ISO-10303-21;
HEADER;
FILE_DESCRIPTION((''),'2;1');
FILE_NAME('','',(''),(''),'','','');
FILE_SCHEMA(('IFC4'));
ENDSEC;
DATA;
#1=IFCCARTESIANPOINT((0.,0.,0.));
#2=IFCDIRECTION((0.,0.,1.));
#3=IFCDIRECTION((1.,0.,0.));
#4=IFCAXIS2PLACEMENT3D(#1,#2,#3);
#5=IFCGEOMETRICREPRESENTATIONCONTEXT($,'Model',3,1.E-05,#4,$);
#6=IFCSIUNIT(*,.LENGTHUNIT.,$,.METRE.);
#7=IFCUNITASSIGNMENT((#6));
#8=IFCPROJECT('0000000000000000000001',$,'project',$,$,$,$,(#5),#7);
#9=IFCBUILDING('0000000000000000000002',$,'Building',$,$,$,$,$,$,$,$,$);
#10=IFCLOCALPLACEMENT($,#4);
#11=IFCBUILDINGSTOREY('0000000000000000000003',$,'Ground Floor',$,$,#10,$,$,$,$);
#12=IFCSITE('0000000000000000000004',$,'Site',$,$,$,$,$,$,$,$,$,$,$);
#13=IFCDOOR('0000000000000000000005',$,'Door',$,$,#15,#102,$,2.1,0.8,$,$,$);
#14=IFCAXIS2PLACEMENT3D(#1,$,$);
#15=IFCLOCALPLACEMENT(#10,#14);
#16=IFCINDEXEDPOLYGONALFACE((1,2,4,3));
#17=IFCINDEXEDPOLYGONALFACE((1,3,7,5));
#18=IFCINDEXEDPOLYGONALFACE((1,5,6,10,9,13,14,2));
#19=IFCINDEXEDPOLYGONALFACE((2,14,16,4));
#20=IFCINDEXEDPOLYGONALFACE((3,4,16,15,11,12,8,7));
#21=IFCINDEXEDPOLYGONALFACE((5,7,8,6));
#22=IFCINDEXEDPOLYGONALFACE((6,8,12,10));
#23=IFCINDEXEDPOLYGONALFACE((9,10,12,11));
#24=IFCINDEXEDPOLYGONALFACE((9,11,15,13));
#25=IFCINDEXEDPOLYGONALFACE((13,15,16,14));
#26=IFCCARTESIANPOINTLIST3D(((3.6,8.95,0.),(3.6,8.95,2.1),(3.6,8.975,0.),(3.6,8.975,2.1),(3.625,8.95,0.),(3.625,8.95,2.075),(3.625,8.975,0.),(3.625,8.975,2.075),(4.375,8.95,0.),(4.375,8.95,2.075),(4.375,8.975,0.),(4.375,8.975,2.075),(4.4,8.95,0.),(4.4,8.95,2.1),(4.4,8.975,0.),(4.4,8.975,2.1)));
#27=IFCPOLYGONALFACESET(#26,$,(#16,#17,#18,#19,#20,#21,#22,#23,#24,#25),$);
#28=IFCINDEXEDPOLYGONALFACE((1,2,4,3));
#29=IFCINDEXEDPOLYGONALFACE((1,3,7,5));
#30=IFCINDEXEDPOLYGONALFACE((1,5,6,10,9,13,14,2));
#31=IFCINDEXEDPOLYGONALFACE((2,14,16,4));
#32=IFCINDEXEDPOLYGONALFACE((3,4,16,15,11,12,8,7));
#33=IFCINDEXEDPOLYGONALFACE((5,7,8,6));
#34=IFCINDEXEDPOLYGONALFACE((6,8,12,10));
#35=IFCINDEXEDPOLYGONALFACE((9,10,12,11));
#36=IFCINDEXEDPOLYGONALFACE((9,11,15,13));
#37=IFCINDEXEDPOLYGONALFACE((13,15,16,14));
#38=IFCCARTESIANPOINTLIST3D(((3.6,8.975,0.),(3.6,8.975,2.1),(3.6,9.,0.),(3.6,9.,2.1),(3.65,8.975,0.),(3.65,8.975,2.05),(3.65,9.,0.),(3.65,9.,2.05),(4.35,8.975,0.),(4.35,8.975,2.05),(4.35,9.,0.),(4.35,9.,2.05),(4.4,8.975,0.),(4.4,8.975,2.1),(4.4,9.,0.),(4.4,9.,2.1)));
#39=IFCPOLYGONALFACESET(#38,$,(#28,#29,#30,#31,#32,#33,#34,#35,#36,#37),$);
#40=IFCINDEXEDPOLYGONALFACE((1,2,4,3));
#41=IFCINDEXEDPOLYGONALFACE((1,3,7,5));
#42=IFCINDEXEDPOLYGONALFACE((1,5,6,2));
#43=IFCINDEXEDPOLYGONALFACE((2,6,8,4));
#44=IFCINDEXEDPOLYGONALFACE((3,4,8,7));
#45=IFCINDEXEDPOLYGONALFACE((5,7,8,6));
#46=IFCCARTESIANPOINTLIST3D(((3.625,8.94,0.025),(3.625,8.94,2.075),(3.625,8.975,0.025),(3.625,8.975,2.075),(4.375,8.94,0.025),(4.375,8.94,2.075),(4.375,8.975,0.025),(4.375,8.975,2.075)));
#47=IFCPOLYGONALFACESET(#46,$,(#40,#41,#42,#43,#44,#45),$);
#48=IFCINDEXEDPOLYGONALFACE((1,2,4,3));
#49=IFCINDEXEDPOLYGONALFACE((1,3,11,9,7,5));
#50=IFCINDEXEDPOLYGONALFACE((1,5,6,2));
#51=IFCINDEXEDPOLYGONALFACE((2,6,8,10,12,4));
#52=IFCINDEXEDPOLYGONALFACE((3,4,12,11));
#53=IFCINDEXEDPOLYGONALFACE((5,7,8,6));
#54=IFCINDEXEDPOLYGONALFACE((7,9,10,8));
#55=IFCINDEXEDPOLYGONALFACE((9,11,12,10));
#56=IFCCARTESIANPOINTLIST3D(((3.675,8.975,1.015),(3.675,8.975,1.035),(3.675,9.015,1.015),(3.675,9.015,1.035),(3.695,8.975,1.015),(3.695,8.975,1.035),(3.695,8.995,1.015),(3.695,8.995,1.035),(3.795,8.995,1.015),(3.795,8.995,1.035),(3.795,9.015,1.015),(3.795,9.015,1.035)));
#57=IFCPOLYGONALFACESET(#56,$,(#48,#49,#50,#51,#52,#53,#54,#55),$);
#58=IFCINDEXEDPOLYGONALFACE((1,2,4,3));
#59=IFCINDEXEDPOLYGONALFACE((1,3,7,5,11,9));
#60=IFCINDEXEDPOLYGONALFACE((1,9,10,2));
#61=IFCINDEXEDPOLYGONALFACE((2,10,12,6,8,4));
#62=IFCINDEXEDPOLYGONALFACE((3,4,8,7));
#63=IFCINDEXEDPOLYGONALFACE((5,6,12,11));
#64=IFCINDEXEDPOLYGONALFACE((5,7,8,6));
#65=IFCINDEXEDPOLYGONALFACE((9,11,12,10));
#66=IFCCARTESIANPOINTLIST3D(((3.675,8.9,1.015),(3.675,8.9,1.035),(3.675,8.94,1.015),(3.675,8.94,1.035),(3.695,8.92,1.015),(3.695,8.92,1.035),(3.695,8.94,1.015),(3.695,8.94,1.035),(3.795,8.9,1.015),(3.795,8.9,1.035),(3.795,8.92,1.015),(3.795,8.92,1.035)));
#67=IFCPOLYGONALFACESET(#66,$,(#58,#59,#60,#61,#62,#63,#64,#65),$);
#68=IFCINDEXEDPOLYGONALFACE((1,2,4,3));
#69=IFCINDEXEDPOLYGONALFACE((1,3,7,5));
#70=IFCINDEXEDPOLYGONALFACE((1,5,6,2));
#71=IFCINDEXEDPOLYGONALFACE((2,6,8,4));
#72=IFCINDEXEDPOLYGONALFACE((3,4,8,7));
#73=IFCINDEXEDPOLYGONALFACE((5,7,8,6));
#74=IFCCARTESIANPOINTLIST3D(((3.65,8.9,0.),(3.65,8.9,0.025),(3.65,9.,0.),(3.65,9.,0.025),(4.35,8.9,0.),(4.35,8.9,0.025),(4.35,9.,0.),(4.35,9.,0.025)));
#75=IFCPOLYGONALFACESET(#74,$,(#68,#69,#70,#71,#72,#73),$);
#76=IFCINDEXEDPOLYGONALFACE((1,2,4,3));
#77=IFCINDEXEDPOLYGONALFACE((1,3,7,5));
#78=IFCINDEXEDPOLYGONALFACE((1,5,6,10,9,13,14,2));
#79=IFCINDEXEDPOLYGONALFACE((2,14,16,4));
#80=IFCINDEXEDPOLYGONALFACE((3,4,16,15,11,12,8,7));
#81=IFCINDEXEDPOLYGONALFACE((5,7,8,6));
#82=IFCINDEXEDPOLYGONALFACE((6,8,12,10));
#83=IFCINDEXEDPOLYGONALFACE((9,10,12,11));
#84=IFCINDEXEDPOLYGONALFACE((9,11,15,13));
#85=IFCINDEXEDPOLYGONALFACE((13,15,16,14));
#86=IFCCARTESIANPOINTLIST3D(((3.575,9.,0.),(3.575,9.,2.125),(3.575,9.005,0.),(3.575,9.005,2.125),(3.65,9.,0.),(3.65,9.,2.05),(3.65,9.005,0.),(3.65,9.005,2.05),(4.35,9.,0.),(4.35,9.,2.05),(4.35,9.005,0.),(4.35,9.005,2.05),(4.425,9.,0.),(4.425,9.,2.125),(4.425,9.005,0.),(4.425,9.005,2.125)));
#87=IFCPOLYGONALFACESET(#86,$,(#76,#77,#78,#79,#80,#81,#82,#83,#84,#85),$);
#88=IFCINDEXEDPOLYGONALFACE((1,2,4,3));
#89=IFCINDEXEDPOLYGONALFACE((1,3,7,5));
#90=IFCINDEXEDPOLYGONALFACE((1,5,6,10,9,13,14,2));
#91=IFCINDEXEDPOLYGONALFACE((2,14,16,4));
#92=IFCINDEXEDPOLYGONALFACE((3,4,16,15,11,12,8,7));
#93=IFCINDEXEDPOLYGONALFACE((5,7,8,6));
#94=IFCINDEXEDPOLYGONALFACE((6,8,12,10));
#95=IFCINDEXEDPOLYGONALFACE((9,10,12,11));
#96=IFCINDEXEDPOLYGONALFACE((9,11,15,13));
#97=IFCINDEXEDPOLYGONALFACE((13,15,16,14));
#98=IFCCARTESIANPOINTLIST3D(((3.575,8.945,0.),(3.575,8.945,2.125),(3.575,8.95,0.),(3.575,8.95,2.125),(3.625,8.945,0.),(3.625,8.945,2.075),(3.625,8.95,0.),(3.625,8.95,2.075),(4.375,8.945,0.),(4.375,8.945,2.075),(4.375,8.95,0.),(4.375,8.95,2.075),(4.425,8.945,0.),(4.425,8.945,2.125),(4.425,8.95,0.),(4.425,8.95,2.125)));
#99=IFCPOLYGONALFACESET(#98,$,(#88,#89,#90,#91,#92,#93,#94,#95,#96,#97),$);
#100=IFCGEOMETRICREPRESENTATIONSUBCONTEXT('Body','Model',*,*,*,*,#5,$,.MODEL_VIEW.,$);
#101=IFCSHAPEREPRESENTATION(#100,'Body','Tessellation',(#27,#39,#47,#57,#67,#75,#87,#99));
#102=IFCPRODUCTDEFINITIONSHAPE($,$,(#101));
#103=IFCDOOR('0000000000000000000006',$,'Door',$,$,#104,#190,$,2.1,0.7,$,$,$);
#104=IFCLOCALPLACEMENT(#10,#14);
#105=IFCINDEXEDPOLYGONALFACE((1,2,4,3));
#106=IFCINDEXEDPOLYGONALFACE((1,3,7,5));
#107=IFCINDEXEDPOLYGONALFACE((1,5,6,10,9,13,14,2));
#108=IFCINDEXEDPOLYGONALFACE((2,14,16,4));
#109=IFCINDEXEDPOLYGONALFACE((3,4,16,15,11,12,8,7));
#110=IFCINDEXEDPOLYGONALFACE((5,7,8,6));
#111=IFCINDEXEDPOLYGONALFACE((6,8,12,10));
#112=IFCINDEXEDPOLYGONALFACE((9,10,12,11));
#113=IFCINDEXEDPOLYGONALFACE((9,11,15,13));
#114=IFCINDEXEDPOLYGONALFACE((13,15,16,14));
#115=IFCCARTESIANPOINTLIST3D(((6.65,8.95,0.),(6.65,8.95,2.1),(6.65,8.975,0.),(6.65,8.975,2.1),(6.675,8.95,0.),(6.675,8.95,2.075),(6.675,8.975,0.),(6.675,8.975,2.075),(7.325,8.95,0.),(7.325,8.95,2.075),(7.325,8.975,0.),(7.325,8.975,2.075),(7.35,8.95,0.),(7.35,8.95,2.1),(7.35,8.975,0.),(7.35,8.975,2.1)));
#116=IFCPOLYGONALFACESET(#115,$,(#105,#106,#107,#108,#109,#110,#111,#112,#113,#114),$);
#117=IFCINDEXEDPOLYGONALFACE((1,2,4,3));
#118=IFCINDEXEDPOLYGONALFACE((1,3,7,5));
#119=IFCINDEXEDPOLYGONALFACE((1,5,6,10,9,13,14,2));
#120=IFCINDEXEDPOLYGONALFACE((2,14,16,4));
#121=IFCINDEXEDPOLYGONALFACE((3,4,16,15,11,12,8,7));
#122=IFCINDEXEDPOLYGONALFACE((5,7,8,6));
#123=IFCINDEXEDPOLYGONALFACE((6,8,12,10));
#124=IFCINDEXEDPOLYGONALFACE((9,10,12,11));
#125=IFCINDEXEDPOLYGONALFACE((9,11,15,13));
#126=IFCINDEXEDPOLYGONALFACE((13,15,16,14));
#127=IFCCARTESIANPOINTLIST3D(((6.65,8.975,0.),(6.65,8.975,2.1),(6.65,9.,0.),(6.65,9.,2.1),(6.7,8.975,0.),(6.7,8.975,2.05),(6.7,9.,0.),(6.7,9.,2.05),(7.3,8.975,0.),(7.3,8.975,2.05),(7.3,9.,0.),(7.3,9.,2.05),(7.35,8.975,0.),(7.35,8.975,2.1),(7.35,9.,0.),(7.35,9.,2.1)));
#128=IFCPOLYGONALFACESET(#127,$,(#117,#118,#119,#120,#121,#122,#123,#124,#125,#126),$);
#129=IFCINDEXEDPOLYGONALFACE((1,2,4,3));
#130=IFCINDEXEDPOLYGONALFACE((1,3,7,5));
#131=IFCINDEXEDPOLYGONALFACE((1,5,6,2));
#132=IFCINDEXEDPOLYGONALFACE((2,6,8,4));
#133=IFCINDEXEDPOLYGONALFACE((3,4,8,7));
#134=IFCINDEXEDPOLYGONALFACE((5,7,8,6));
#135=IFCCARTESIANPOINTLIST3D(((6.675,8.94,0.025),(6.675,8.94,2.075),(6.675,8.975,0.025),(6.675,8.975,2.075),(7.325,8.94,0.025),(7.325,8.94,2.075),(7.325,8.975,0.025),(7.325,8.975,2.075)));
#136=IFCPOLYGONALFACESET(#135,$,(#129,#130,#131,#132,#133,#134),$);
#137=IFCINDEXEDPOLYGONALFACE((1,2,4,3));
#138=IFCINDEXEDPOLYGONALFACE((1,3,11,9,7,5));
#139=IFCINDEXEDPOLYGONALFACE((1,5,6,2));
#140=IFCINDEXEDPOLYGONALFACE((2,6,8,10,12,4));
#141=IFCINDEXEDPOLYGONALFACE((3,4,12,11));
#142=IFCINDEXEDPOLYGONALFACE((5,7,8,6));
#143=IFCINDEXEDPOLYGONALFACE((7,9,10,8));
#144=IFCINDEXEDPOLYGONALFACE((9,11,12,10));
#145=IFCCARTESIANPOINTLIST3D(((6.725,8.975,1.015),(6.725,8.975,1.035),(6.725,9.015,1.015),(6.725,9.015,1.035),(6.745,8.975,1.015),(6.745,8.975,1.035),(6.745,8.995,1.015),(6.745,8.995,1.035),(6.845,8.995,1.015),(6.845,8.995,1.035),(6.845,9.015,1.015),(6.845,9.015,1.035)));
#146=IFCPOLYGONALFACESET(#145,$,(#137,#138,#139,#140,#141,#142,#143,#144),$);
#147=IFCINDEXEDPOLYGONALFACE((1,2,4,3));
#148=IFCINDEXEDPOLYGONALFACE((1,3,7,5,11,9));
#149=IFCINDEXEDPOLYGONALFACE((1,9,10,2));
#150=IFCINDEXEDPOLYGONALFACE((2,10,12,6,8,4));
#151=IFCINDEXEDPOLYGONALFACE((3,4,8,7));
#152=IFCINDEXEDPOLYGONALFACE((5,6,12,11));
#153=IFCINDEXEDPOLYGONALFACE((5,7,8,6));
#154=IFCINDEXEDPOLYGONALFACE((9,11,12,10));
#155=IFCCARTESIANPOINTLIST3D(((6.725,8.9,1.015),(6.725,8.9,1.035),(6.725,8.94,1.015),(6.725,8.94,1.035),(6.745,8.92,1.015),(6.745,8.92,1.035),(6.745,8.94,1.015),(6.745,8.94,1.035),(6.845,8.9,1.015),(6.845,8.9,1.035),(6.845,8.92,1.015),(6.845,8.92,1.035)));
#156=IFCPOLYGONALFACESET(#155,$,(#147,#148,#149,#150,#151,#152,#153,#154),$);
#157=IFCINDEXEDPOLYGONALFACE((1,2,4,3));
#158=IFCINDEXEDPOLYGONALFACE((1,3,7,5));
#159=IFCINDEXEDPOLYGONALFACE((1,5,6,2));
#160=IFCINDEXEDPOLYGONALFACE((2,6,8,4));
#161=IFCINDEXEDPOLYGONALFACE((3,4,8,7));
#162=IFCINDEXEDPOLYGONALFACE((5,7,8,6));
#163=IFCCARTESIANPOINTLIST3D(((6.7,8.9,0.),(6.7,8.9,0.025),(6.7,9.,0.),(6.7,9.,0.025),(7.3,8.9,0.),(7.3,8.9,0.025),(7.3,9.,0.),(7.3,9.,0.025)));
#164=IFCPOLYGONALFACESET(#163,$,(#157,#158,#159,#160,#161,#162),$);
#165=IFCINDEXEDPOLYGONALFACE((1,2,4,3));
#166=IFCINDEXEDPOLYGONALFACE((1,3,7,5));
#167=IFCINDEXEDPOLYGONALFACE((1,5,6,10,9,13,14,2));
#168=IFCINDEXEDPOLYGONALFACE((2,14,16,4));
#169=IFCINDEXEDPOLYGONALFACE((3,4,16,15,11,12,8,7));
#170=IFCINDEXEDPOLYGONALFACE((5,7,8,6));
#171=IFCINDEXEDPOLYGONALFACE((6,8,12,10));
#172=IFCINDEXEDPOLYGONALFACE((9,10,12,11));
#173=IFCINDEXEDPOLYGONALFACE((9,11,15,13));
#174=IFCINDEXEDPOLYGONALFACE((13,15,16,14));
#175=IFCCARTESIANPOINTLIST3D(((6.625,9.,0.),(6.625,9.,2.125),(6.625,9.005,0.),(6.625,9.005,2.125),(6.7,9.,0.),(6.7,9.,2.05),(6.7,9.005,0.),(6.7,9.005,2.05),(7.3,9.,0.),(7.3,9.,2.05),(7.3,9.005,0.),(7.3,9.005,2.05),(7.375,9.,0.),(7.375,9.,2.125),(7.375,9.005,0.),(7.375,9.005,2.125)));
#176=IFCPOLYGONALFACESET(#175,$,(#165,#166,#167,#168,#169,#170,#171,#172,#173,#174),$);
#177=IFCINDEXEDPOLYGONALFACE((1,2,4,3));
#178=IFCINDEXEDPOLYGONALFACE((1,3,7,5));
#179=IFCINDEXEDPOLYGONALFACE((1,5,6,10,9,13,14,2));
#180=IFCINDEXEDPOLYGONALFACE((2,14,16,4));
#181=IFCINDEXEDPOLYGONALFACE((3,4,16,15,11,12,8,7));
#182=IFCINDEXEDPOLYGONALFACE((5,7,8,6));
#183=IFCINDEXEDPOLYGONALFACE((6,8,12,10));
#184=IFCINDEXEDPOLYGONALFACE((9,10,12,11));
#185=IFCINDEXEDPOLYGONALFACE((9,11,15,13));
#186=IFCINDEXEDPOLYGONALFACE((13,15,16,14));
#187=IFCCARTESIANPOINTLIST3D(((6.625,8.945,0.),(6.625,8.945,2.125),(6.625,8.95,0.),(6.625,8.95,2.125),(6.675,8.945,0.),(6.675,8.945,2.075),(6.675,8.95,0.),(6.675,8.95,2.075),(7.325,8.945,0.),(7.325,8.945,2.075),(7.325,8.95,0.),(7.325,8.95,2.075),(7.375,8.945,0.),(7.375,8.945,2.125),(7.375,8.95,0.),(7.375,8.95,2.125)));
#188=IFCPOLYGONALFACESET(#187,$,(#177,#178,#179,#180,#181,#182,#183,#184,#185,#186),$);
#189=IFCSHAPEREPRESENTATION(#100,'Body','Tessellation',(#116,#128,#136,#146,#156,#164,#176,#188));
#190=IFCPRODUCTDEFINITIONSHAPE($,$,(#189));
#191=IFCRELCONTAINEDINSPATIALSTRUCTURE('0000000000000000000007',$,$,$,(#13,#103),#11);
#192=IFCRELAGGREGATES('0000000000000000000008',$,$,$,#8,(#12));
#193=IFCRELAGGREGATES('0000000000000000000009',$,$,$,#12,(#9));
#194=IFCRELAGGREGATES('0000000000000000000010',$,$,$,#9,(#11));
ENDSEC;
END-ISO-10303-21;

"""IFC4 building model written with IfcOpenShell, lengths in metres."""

from ifc_helpers import new_model, si_unit, frame, origin_with_axes, place, context, subcontext, project, spatial, line, indexed_curve, outline, extrude, element, save


model = new_model("IFC4")

# Units and contexts
model_context = context("Model", 3, precision=1e-05, world=origin_with_axes())
body_context = subcontext(model_context, "Body", "Model", "MODEL_VIEW")
ifc_project = project(units=[si_unit("LENGTHUNIT", "METRE")], contexts=[model_context])

# Site, building, storey
site = spatial("IfcSite", under=ifc_project, Name="Site")
building = spatial("IfcBuilding", under=site, Name="Building")
storey_placement = place(None, origin_with_axes())
storey = spatial("IfcBuildingStorey", under=building, at=storey_placement, Name="Ground Floor")

# Doors
door_1_placement = place(storey_placement, frame((4.4, 9.0, 0.0), z_axis=(0.0, 0.0, 1.0), x_axis=(-1.0, 0.0, 0.0)))
element("IfcDoor", 1, at=door_1_placement, inside=storey, Name="Door", OverallHeight=2.1, OverallWidth=0.8, context=body_context, shape_type="SweptSolid", body=[
    extrude(outline(indexed_curve([(0.0, 0.0), (0.0, 2.1), (0.8, 2.1), (0.8, 0.0), (0.775, 0.0), (0.775, 2.075), (0.025, 2.075), (0.025, 0.0)], segments=[line(1, 2, 3, 4, 5, 6, 7, 8, 1)])), frame((0.0, 0.025, 0.0), z_axis=(0.0, -1.0, 0.0), x_axis=(1.0, 0.0, 0.0)), (0.0, 0.0, -1.0), 0.025),
    extrude(outline(indexed_curve([(0.0, 0.0), (0.0, 2.1), (0.8, 2.1), (0.8, 0.0), (0.75, 0.0), (0.75, 2.05), (0.05, 2.05), (0.05, 0.0)], segments=[line(1, 2, 3, 4, 5, 6, 7, 8, 1)])), frame((0.0, 0.0, 0.0), z_axis=(0.0, -1.0, 0.0), x_axis=(1.0, 0.0, 0.0)), (0.0, 0.0, -1.0), 0.025),
    extrude(outline(indexed_curve([(0.0, 0.0), (0.75, 0.0), (0.75, 0.035), (0.0, 0.035)], segments=[line(1, 2, 3, 4, 1)])), frame((0.025, 0.025, 0.025), z_axis=(0.0, 0.0, 1.0), x_axis=(1.0, 0.0, 0.0)), (0.0, 0.0, 1.0), 2.05),
    extrude(outline(indexed_curve([(0.0, 0.0), (0.0, -0.04), (-0.12, -0.04), (-0.12, -0.02), (-0.02, -0.02), (-0.02, 0.0)], segments=[line(1, 2, 3, 4, 5, 6, 1)])), frame((0.725, 0.025, 1.015), z_axis=(0.0, 0.0, 1.0), x_axis=(1.0, 0.0, 0.0)), (0.0, 0.0, 1.0), 0.02),
    extrude(outline(indexed_curve([(0.0, 0.0), (0.0, 0.04), (-0.12, 0.04), (-0.12, 0.02), (-0.02, 0.02), (-0.02, 0.0)], segments=[line(1, 2, 3, 4, 5, 6, 1)])), frame((0.725, 0.06, 1.015), z_axis=(0.0, 0.0, 1.0), x_axis=(1.0, 0.0, 0.0)), (0.0, 0.0, 1.0), 0.02),
    extrude(outline(indexed_curve([(0.0, 0.0), (0.7, 0.0), (0.7, 0.1), (0.0, 0.1)], segments=[line(1, 2, 3, 4, 1)])), frame((0.05, 0.0, 0.0), z_axis=(0.0, 0.0, 1.0), x_axis=(1.0, 0.0, 0.0)), (0.0, 0.0, 1.0), 0.025),
    extrude(outline(indexed_curve([(0.0, 0.0), (0.0, 2.125), (0.85, 2.125), (0.85, 0.0), (0.775, 0.0), (0.775, 2.05), (0.075, 2.05), (0.075, 0.0)], segments=[line(1, 2, 3, 4, 5, 6, 7, 8, 1)])), frame((-0.025, -0.005, 0.0), z_axis=(0.0, -1.0, 0.0), x_axis=(1.0, 0.0, 0.0)), (0.0, 0.0, -1.0), 0.005),
    extrude(outline(indexed_curve([(0.0, 0.0), (0.0, 2.125), (0.85, 2.125), (0.85, 0.0), (0.8, 0.0), (0.8, 2.075), (0.05, 2.075), (0.05, 0.0)], segments=[line(1, 2, 3, 4, 5, 6, 7, 8, 1)])), frame((-0.025, 0.05, 0.0), z_axis=(0.0, -1.0, 0.0), x_axis=(1.0, 0.0, 0.0)), (0.0, 0.0, -1.0), 0.005),
])
door_2_placement = place(storey_placement, frame((7.35, 9.0, 0.0), z_axis=(0.0, 0.0, 1.0), x_axis=(-1.0, 0.0, 0.0)))
element("IfcDoor", 2, at=door_2_placement, inside=storey, Name="Door", OverallHeight=2.1, OverallWidth=0.7, context=body_context, shape_type="SweptSolid", body=[
    extrude(outline(indexed_curve([(0.0, 0.0), (0.0, 2.1), (0.7, 2.1), (0.7, 0.0), (0.675, 0.0), (0.675, 2.075), (0.025, 2.075), (0.025, 0.0)], segments=[line(1, 2, 3, 4, 5, 6, 7, 8, 1)])), frame((0.0, 0.025, 0.0), z_axis=(0.0, -1.0, 0.0), x_axis=(1.0, 0.0, 0.0)), (0.0, 0.0, -1.0), 0.025),
    extrude(outline(indexed_curve([(0.0, 0.0), (0.0, 2.1), (0.7, 2.1), (0.7, 0.0), (0.65, 0.0), (0.65, 2.05), (0.05, 2.05), (0.05, 0.0)], segments=[line(1, 2, 3, 4, 5, 6, 7, 8, 1)])), frame((0.0, 0.0, 0.0), z_axis=(0.0, -1.0, 0.0), x_axis=(1.0, 0.0, 0.0)), (0.0, 0.0, -1.0), 0.025),
    extrude(outline(indexed_curve([(0.0, 0.0), (0.65, 0.0), (0.65, 0.035), (0.0, 0.035)], segments=[line(1, 2, 3, 4, 1)])), frame((0.025, 0.025, 0.025), z_axis=(0.0, 0.0, 1.0), x_axis=(1.0, 0.0, 0.0)), (0.0, 0.0, 1.0), 2.05),
    extrude(outline(indexed_curve([(0.0, 0.0), (0.0, -0.04), (-0.12, -0.04), (-0.12, -0.02), (-0.02, -0.02), (-0.02, 0.0)], segments=[line(1, 2, 3, 4, 5, 6, 1)])), frame((0.625, 0.025, 1.015), z_axis=(0.0, 0.0, 1.0), x_axis=(1.0, 0.0, 0.0)), (0.0, 0.0, 1.0), 0.02),
    extrude(outline(indexed_curve([(0.0, 0.0), (0.0, 0.04), (-0.12, 0.04), (-0.12, 0.02), (-0.02, 0.02), (-0.02, 0.0)], segments=[line(1, 2, 3, 4, 5, 6, 1)])), frame((0.625, 0.06, 1.015), z_axis=(0.0, 0.0, 1.0), x_axis=(1.0, 0.0, 0.0)), (0.0, 0.0, 1.0), 0.02),
    extrude(outline(indexed_curve([(0.0, 0.0), (0.6, 0.0), (0.6, 0.1), (0.0, 0.1)], segments=[line(1, 2, 3, 4, 1)])), frame((0.05, 0.0, 0.0), z_axis=(0.0, 0.0, 1.0), x_axis=(1.0, 0.0, 0.0)), (0.0, 0.0, 1.0), 0.025),
    extrude(outline(indexed_curve([(0.0, 0.0), (0.0, 2.125), (0.75, 2.125), (0.75, 0.0), (0.675, 0.0), (0.675, 2.05), (0.075, 2.05), (0.075, 0.0)], segments=[line(1, 2, 3, 4, 5, 6, 7, 8, 1)])), frame((-0.025, -0.005, 0.0), z_axis=(0.0, -1.0, 0.0), x_axis=(1.0, 0.0, 0.0)), (0.0, 0.0, -1.0), 0.005),
    extrude(outline(indexed_curve([(0.0, 0.0), (0.0, 2.125), (0.75, 2.125), (0.75, 0.0), (0.7, 0.0), (0.7, 2.075), (0.05, 2.075), (0.05, 0.0)], segments=[line(1, 2, 3, 4, 5, 6, 7, 8, 1)])), frame((-0.025, 0.05, 0.0), z_axis=(0.0, -1.0, 0.0), x_axis=(1.0, 0.0, 0.0)), (0.0, 0.0, -1.0), 0.005),
])

save(model, "model.ifc")
